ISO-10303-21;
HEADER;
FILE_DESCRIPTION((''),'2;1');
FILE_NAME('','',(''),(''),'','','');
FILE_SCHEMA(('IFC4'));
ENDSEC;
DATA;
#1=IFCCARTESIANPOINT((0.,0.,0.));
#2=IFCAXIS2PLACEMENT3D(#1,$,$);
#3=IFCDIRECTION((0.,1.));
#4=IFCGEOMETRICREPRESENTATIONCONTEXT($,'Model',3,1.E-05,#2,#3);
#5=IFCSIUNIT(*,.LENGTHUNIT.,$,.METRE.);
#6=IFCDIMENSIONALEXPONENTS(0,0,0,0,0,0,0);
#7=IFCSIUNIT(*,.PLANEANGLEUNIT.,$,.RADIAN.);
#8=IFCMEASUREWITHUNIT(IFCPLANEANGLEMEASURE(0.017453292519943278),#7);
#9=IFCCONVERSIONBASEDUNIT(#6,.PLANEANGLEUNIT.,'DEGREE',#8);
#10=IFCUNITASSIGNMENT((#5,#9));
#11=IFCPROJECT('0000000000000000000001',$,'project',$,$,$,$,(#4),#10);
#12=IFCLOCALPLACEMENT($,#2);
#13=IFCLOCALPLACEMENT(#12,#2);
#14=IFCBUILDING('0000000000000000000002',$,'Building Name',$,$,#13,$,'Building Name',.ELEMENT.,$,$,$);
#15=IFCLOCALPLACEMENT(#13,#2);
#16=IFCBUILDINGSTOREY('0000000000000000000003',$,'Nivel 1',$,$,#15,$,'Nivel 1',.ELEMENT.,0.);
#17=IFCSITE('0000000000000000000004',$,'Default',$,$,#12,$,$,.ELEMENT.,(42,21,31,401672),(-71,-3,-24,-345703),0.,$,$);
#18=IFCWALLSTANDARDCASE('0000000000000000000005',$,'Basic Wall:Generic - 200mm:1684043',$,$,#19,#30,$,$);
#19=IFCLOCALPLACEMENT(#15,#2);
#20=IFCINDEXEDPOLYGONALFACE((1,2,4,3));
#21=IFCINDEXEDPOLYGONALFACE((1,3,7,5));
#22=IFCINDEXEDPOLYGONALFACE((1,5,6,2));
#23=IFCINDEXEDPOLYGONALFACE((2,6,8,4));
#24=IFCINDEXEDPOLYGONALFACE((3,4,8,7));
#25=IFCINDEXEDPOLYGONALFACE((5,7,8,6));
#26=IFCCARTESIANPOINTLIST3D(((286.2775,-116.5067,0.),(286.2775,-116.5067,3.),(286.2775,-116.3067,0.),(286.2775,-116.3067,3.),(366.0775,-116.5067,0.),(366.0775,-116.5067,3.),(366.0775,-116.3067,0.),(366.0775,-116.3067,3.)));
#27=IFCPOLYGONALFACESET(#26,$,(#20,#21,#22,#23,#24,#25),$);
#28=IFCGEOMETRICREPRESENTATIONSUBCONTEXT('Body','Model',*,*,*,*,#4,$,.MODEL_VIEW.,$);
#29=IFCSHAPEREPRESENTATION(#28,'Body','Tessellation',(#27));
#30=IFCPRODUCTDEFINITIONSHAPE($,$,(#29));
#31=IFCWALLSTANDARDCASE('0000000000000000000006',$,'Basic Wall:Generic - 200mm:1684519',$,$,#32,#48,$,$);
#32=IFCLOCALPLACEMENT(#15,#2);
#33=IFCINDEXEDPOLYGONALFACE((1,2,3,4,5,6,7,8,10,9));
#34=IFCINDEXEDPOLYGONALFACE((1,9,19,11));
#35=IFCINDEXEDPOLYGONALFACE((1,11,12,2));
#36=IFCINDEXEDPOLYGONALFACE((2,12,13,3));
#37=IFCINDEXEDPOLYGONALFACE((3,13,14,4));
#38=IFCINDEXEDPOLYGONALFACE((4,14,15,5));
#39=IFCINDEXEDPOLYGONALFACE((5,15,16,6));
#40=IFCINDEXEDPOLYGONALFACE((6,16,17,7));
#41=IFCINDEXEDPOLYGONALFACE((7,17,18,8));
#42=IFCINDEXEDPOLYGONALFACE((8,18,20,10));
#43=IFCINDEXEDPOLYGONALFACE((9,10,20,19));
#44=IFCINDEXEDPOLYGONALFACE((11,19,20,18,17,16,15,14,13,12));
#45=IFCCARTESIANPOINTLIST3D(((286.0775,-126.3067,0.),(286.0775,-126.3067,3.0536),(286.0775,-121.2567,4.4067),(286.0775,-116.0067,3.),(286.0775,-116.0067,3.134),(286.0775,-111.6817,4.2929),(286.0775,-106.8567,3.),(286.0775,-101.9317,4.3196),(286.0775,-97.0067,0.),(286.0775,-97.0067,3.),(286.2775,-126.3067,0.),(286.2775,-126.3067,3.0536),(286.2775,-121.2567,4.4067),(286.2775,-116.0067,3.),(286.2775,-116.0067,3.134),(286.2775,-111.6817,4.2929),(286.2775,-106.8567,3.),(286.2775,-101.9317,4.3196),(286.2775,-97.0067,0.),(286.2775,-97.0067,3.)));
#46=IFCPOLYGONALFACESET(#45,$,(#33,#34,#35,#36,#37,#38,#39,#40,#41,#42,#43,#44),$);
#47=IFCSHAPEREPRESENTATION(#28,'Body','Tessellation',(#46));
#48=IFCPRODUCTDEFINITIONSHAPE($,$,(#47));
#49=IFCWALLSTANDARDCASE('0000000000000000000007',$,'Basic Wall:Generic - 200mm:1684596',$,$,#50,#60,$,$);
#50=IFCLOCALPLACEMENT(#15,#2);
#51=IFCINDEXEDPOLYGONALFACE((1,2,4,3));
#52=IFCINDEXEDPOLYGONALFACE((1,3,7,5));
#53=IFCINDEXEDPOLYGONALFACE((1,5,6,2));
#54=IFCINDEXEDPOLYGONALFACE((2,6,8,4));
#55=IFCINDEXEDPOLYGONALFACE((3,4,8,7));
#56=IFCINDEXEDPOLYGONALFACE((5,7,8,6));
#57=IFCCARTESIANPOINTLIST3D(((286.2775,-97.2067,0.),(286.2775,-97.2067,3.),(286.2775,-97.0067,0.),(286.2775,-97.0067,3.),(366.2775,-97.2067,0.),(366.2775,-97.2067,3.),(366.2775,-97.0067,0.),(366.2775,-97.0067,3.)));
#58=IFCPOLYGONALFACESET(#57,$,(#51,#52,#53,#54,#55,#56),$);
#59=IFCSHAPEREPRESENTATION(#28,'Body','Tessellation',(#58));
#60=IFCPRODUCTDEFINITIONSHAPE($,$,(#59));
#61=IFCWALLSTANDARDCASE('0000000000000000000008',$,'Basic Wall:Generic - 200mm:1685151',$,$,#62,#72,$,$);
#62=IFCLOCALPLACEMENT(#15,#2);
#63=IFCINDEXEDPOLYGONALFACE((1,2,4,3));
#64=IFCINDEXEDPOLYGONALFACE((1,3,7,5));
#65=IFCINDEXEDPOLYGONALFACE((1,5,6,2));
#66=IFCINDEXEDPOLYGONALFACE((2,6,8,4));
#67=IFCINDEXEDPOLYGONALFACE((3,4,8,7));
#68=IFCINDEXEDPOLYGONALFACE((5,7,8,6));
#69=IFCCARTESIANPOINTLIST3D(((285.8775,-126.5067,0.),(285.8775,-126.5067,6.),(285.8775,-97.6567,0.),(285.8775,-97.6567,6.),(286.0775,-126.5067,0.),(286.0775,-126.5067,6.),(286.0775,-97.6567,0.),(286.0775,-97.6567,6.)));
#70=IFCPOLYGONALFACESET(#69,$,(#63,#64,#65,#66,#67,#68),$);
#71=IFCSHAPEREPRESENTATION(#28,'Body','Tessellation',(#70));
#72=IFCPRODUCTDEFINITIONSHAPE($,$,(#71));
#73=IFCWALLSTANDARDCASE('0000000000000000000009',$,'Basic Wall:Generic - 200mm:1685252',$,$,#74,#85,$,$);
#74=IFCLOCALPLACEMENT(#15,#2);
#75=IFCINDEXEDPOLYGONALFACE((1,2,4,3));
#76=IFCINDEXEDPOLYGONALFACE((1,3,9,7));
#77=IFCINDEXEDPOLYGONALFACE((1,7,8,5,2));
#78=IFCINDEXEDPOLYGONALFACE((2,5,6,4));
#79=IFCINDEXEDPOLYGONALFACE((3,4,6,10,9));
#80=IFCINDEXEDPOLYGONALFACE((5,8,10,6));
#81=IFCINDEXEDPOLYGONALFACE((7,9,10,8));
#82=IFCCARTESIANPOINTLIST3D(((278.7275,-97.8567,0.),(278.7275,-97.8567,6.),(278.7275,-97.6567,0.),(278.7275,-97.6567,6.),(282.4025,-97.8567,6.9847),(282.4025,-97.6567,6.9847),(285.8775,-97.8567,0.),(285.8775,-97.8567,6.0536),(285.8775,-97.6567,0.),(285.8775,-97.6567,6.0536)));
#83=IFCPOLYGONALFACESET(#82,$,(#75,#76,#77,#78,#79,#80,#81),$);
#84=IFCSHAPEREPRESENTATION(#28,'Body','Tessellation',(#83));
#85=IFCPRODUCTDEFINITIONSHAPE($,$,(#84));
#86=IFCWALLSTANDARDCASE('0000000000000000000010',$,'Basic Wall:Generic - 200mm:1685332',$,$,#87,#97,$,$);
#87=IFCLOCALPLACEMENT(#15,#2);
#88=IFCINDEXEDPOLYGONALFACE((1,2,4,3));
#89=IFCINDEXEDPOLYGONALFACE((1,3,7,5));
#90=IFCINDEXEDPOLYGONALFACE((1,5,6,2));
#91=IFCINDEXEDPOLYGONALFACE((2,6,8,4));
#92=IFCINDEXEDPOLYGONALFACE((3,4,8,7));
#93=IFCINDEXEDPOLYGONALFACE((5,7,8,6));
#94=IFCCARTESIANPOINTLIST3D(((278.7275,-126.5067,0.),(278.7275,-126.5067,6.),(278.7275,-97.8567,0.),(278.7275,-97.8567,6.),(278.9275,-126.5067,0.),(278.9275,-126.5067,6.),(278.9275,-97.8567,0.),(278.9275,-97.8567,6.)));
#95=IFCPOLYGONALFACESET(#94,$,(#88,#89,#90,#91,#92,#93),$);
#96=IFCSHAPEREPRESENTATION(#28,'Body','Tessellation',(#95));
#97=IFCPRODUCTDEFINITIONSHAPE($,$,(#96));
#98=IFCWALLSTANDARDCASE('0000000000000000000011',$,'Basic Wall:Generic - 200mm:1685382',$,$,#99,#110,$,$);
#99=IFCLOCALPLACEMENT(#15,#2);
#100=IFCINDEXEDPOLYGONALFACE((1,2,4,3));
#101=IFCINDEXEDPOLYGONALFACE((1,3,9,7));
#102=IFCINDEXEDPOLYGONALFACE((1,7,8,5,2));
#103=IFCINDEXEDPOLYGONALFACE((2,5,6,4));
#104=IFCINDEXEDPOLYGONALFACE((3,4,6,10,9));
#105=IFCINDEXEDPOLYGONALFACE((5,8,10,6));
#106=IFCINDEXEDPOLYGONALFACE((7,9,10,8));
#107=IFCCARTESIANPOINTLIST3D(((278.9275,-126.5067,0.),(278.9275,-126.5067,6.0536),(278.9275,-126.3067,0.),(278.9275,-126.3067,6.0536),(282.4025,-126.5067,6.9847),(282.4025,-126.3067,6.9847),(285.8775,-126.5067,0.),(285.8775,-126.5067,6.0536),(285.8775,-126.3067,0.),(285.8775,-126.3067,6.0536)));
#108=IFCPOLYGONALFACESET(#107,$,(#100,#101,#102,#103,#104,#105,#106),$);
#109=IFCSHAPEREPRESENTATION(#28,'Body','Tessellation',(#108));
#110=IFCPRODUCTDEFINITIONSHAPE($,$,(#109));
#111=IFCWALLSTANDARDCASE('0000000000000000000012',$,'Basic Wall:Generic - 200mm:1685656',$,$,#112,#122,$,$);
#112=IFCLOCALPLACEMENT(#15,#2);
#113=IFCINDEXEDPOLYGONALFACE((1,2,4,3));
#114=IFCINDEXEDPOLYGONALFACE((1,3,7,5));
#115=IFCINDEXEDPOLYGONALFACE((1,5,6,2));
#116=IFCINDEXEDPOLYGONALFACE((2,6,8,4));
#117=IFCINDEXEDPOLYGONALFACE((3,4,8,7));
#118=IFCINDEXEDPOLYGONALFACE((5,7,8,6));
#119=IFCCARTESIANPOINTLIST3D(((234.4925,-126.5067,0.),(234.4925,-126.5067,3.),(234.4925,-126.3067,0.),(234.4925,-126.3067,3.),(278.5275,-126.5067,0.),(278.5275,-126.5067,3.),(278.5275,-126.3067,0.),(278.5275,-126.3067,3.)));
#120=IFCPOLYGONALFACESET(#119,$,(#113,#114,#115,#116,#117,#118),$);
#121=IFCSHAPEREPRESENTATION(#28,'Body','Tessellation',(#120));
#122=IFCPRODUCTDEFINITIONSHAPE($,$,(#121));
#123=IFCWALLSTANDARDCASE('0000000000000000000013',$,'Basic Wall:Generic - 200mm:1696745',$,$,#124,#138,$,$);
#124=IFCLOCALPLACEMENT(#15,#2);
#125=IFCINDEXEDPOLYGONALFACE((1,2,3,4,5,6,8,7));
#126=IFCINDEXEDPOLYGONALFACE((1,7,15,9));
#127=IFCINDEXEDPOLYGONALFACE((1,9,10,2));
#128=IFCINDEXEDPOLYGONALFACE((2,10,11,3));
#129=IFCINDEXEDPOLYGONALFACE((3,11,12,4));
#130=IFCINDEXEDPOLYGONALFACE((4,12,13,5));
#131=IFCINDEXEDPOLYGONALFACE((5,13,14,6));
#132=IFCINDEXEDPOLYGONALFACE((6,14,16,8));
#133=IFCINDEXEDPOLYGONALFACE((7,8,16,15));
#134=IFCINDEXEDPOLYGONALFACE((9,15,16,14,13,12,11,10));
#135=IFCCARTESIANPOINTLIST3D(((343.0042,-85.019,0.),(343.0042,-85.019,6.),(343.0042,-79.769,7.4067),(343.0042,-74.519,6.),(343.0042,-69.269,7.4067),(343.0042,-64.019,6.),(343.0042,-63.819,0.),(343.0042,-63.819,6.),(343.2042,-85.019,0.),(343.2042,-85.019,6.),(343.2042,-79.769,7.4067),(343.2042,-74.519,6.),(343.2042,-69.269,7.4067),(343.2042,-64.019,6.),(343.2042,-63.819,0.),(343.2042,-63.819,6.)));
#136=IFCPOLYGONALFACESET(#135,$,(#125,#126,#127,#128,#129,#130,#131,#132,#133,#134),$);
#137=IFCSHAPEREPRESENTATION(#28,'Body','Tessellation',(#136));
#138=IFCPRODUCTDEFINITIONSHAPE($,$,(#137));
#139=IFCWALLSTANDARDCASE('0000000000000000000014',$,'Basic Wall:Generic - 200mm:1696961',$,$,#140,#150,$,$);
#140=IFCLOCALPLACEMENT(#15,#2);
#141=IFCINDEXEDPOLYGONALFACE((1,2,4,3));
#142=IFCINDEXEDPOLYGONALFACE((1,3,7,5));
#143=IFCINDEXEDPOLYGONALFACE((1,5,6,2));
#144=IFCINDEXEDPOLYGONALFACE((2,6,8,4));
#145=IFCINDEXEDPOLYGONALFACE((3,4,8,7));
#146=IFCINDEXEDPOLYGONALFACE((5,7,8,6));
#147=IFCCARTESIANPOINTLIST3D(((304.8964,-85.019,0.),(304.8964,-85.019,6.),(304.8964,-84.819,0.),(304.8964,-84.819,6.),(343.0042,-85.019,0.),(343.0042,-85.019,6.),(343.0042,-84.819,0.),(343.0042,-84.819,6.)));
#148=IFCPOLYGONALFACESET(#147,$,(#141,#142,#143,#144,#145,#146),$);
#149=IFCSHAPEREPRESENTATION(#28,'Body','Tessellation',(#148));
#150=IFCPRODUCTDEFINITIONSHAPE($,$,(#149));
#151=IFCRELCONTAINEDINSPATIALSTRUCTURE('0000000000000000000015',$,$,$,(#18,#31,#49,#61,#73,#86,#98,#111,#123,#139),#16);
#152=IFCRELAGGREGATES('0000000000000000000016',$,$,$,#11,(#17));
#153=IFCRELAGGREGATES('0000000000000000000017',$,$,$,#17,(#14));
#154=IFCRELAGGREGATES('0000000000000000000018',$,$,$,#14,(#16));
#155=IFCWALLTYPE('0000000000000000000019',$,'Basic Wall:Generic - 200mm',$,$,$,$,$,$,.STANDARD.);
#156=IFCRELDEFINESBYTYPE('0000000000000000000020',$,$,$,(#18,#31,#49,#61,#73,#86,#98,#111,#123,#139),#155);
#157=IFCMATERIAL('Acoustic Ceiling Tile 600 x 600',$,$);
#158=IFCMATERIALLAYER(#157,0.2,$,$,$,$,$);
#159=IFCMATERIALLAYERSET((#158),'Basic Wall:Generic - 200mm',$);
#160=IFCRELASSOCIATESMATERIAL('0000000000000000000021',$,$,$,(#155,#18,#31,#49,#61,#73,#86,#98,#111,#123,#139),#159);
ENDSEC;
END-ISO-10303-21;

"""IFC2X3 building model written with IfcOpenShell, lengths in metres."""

from ifc_helpers import new_model, entity, si_unit, converted_unit, direction, frame, frame_2d, origin, place, context, subcontext, project, spatial, polyline, rectangle, extrude, clip, bounded_halfspace, material, layer, layer_set, layer_usage, type_object, element, save


model = new_model("IFC2X3")

# Units and contexts
model_context = context("Model", 3, precision=1e-05, world=origin(), true_north=direction((0.0, 1.0)))
body_context = subcontext(model_context, "Body", "Model", "MODEL_VIEW")
ifc_project = project(units=[si_unit("LENGTHUNIT", "METRE"), converted_unit("PLANEANGLEUNIT", "DEGREE", entity("IfcPlaneAngleMeasure", 0.017453292519943278), si_unit("PLANEANGLEUNIT", "RADIAN"), dimensions=[0, 0, 0, 0, 0, 0, 0])], contexts=[model_context])

# Site, building, storey
site_placement = place(None, origin())
site = spatial("IfcSite", under=ifc_project, at=site_placement, Name="Default", CompositionType="ELEMENT", RefLatitude=(42, 21, 31, 401672), RefLongitude=(-71, -3, -24, -345703), RefElevation=0.0)
building_placement = place(site_placement, origin())
building = spatial("IfcBuilding", under=site, at=building_placement, Name="Building Name", LongName="Building Name", CompositionType="ELEMENT")
storey_placement = place(building_placement, origin())
storey = spatial("IfcBuildingStorey", under=building, at=storey_placement, Name="Nivel 1", LongName="Nivel 1", CompositionType="ELEMENT", Elevation=0.0)

# Walls
ifc_material_1 = material(Name="Acoustic Ceiling Tile 600 x 600")
ifc_layer = layer(ifc_material_1, 0.2)
ifc_layer_set = layer_set([ifc_layer], Name="Basic Wall:Generic - 200mm")
ifc_layer_usage_1 = layer_usage(ifc_layer_set, "AXIS2", "NEGATIVE", 0.1)
wall_type_1 = type_object("IfcWallType", Name="Basic Wall:Generic - 200mm", PredefinedType="STANDARD", material=ifc_layer_set)
wall_1_placement = place(storey_placement, frame((286.2775, -116.4067, 0.0)))
element("IfcWallStandardCase", 1, at=wall_1_placement, inside=storey, type_object=wall_type_1, material=ifc_layer_usage_1, Name="Basic Wall:Generic - 200mm:1684043", context=body_context, shape_type="SweptSolid", body=[
    extrude(rectangle(XDim=79.8, YDim=0.2, at=frame_2d((39.9, 0.0), x_axis=(-1.0, 0.0))), origin(), (0.0, 0.0, 1.0), 3.0),
])
ifc_layer_usage_2 = layer_usage(ifc_layer_set, "AXIS2", "NEGATIVE", 0.1)
wall_2_placement = place(storey_placement, frame((286.1775, -126.3067, 0.0), z_axis=(0.0, 0.0, 1.0), x_axis=(0.0, 1.0, 0.0)))
element("IfcWallStandardCase", 2, at=wall_2_placement, inside=storey, type_object=wall_type_1, material=ifc_layer_usage_2, Name="Basic Wall:Generic - 200mm:1684519", context=body_context, shape_type="Clipping", body=[
    clip(clip(clip(clip(clip(clip(extrude(rectangle(XDim=29.3, YDim=0.2, at=frame_2d((14.65, 0.0), x_axis=(-1.0, 0.0))), origin(), (0.0, 0.0, 1.0), 4.4067), bounded_halfspace(frame((24.375, -0.1, 4.3196), z_axis=(0.258819, 0.0, 0.965926), x_axis=(0.0, 1.0, 0.0)), False, frame((24.375, -0.1, 4.3196)), polyline([(0.0, 0.0), (4.925, 0.0), (4.925, 0.2), (0.0, 0.2), (0.0, 0.0)]))), bounded_halfspace(frame((14.625, -0.1, 4.2929), z_axis=(0.258819, 0.0, 0.965926), x_axis=(0.0, 1.0, 0.0)), False, frame((14.625, -0.1, 4.2929)), polyline([(0.0, 0.0), (4.825, 0.0), (4.825, 0.2), (0.0, 0.2), (0.0, 0.0)]))), bounded_halfspace(frame((10.3, -0.1, 3.0), z_axis=(0.258819, 0.0, 0.965926), x_axis=(0.0, 1.0, 0.0)), False, frame((10.3, -0.1, 3.0)), polyline([(0.0, 0.0), (0.0, 0.2), (-5.25, 0.2), (-5.25, 0.0), (0.0, 0.0)]))), bounded_halfspace(frame((19.45, -0.1, 3.0), z_axis=(-0.258819, 0.0, 0.965926), x_axis=(0.0, -1.0, 0.0)), False, frame((19.45, -0.1, 3.0)), polyline([(0.0, 0.0), (4.925, 0.0), (4.925, 0.2), (0.0, 0.2), (0.0, 0.0)]))), bounded_halfspace(frame((10.3, -0.1, 3.134), z_axis=(-0.258819, 0.0, 0.965926), x_axis=(0.0, -1.0, 0.0)), False, frame((10.3, -0.1, 3.134)), polyline([(0.0, 0.0), (4.325, 0.0), (4.325, 0.2), (0.0, 0.2), (0.0, 0.0)]))), bounded_halfspace(frame((5.05, 0.1, 4.4067), z_axis=(-0.258819, 0.0, 0.965926), x_axis=(0.0, -1.0, 0.0)), False, frame((5.05, 0.1, 4.4067)), polyline([(0.0, 0.0), (-5.05, 0.0), (-5.05, -0.2), (0.0, -0.2), (0.0, 0.0)]))),
])
ifc_layer_usage_3 = layer_usage(ifc_layer_set, "AXIS2", "NEGATIVE", 0.1)
wall_3_placement = place(storey_placement, frame((286.2775, -97.1067, 0.0)))
element("IfcWallStandardCase", 3, at=wall_3_placement, inside=storey, type_object=wall_type_1, material=ifc_layer_usage_3, Name="Basic Wall:Generic - 200mm:1684596", context=body_context, shape_type="SweptSolid", body=[
    extrude(rectangle(XDim=80.0, YDim=0.2, at=frame_2d((40.0, 0.0), x_axis=(-1.0, 0.0))), origin(), (0.0, 0.0, 1.0), 3.0),
])
ifc_layer_usage_4 = layer_usage(ifc_layer_set, "AXIS2", "NEGATIVE", 0.1)
wall_4_placement = place(storey_placement, frame((285.9775, -126.5067, 0.0), z_axis=(0.0, 0.0, 1.0), x_axis=(0.0, 1.0, 0.0)))
element("IfcWallStandardCase", 4, at=wall_4_placement, inside=storey, type_object=wall_type_1, material=ifc_layer_usage_4, Name="Basic Wall:Generic - 200mm:1685151", context=body_context, shape_type="SweptSolid", body=[
    extrude(rectangle(XDim=28.85, YDim=0.2, at=frame_2d((14.425, 0.0), x_axis=(-1.0, 0.0))), origin(), (0.0, 0.0, 1.0), 6.0),
])
ifc_layer_usage_5 = layer_usage(ifc_layer_set, "AXIS2", "NEGATIVE", 0.1)
wall_5_placement = place(storey_placement, frame((285.8775, -97.7567, 0.0), z_axis=(0.0, 0.0, 1.0), x_axis=(-1.0, 0.0, 0.0)))
element("IfcWallStandardCase", 5, at=wall_5_placement, inside=storey, type_object=wall_type_1, material=ifc_layer_usage_5, Name="Basic Wall:Generic - 200mm:1685252", context=body_context, shape_type="Clipping", body=[
    clip(clip(extrude(rectangle(XDim=7.15, YDim=0.2, at=frame_2d((3.575, 0.0), x_axis=(-1.0, 0.0))), origin(), (0.0, 0.0, 1.0), 6.9847), bounded_halfspace(frame((0.0, -0.1, 6.0536), z_axis=(-0.258819, 0.0, 0.965926), x_axis=(0.0, -1.0, 0.0)), False, frame((0.0, -0.1, 6.0536)), polyline([(0.0, 0.0), (3.475, 0.0), (3.475, 0.2), (0.0, 0.2), (0.0, 0.0)]))), bounded_halfspace(frame((3.475, -0.1, 6.9847), z_axis=(0.258819, 0.0, 0.965926), x_axis=(0.0, 1.0, 0.0)), False, frame((3.475, -0.1, 6.9847)), polyline([(0.0, 0.0), (3.675, 0.0), (3.675, 0.2), (0.0, 0.2), (0.0, 0.0)]))),
])
ifc_layer_usage_6 = layer_usage(ifc_layer_set, "AXIS2", "NEGATIVE", 0.1)
wall_6_placement = place(storey_placement, frame((278.8275, -97.8567, 0.0), z_axis=(0.0, 0.0, 1.0), x_axis=(0.0, -1.0, 0.0)))
element("IfcWallStandardCase", 6, at=wall_6_placement, inside=storey, type_object=wall_type_1, material=ifc_layer_usage_6, Name="Basic Wall:Generic - 200mm:1685332", context=body_context, shape_type="SweptSolid", body=[
    extrude(rectangle(XDim=28.65, YDim=0.2, at=frame_2d((14.325, 0.0), x_axis=(-1.0, 0.0))), origin(), (0.0, 0.0, 1.0), 6.0),
])
ifc_layer_usage_7 = layer_usage(ifc_layer_set, "AXIS2", "NEGATIVE", 0.1)
wall_7_placement = place(storey_placement, frame((278.9275, -126.4067, 0.0)))
element("IfcWallStandardCase", 7, at=wall_7_placement, inside=storey, type_object=wall_type_1, material=ifc_layer_usage_7, Name="Basic Wall:Generic - 200mm:1685382", context=body_context, shape_type="Clipping", body=[
    clip(clip(extrude(rectangle(XDim=6.95, YDim=0.2, at=frame_2d((3.475, 0.0), x_axis=(-1.0, 0.0))), origin(), (0.0, 0.0, 1.0), 6.9847), bounded_halfspace(frame((3.475, -0.1, 6.9847), z_axis=(0.258819, 0.0, 0.965926), x_axis=(0.0, 1.0, 0.0)), False, frame((3.475, -0.1, 6.9847)), polyline([(0.0, 0.0), (3.475, 0.0), (3.475, 0.2), (0.0, 0.2), (0.0, 0.0)]))), bounded_halfspace(frame((0.0, -0.1, 6.0536), z_axis=(-0.258819, 0.0, 0.965926), x_axis=(0.0, -1.0, 0.0)), False, frame((0.0, -0.1, 6.0536)), polyline([(0.0, 0.0), (3.475, 0.0), (3.475, 0.2), (0.0, 0.2), (0.0, 0.0)]))),
])
ifc_layer_usage_8 = layer_usage(ifc_layer_set, "AXIS2", "NEGATIVE", 0.1)
wall_8_placement = place(storey_placement, frame((278.5275, -126.4067, 0.0), z_axis=(0.0, 0.0, 1.0), x_axis=(-1.0, 0.0, 0.0)))
element("IfcWallStandardCase", 8, at=wall_8_placement, inside=storey, type_object=wall_type_1, material=ifc_layer_usage_8, Name="Basic Wall:Generic - 200mm:1685656", context=body_context, shape_type="SweptSolid", body=[
    extrude(rectangle(XDim=44.035, YDim=0.2, at=frame_2d((22.0175, 0.0), x_axis=(-1.0, 0.0))), origin(), (0.0, 0.0, 1.0), 3.0),
])
ifc_layer_usage_9 = layer_usage(ifc_layer_set, "AXIS2", "NEGATIVE", 0.1)
wall_9_placement = place(storey_placement, frame((343.1042, -63.819, 0.0), z_axis=(0.0, 0.0, 1.0), x_axis=(0.0, -1.0, 0.0)))
element("IfcWallStandardCase", 9, at=wall_9_placement, inside=storey, type_object=wall_type_1, material=ifc_layer_usage_9, Name="Basic Wall:Generic - 200mm:1696745", context=body_context, shape_type="Clipping", body=[
    clip(clip(clip(clip(clip(extrude(rectangle(XDim=21.2, YDim=0.2, at=frame_2d((10.6, 0.0), x_axis=(-1.0, 0.0))), origin(), (0.0, 0.0, 1.0), 7.4067), bounded_halfspace(frame((15.95, -0.1, 7.4067), z_axis=(0.258819, 0.0, 0.965926), x_axis=(0.0, 1.0, 0.0)), False, frame((15.95, -0.1, 7.4067)), polyline([(0.0, 0.0), (5.25, 0.0), (5.25, 0.2), (0.0, 0.2), (0.0, 0.0)]))), bounded_halfspace(frame((5.45, -0.1, 7.4067), z_axis=(0.258819, 0.0, 0.965926), x_axis=(0.0, 1.0, 0.0)), False, frame((5.45, -0.1, 7.4067)), polyline([(0.0, 0.0), (5.25, 0.0), (5.25, 0.2), (0.0, 0.2), (0.0, 0.0)]))), bounded_halfspace(frame((10.7, -0.1, 6.0), z_axis=(-0.258819, 0.0, 0.965926), x_axis=(0.0, -1.0, 0.0)), False, frame((10.7, -0.1, 6.0)), polyline([(0.0, 0.0), (5.25, 0.0), (5.25, 0.2), (0.0, 0.2), (0.0, 0.0)]))), bounded_halfspace(frame((0.2, -0.1, 6.0), z_axis=(-0.258819, 0.0, 0.965926), x_axis=(0.0, -1.0, 0.0)), False, frame((0.2, -0.1, 6.0)), polyline([(0.0, 0.0), (5.25, 0.0), (5.25, 0.2), (0.0, 0.2), (0.0, 0.0)]))), bounded_halfspace(frame((0.0, -0.1, 6.0), z_axis=(0.0, 0.0, 1.0), x_axis=(0.0, 1.0, 0.0)), False, frame((0.0, -0.1, 6.0)), polyline([(0.0, 0.0), (0.2, 0.0), (0.2, 0.2), (0.0, 0.2), (0.0, 0.0)]))),
])
ifc_layer_usage_10 = layer_usage(ifc_layer_set, "AXIS2", "NEGATIVE", 0.1)
wall_10_placement = place(storey_placement, frame((343.0042, -84.919, 0.0), z_axis=(0.0, 0.0, 1.0), x_axis=(-1.0, 0.0, 0.0)))
element("IfcWallStandardCase", 10, at=wall_10_placement, inside=storey, type_object=wall_type_1, material=ifc_layer_usage_10, Name="Basic Wall:Generic - 200mm:1696961", context=body_context, shape_type="SweptSolid", body=[
    extrude(rectangle(XDim=38.1079, YDim=0.2, at=frame_2d((19.0539, 0.0), x_axis=(-1.0, 0.0))), origin(), (0.0, 0.0, 1.0), 6.0),
])

save(model, "model.ifc")
